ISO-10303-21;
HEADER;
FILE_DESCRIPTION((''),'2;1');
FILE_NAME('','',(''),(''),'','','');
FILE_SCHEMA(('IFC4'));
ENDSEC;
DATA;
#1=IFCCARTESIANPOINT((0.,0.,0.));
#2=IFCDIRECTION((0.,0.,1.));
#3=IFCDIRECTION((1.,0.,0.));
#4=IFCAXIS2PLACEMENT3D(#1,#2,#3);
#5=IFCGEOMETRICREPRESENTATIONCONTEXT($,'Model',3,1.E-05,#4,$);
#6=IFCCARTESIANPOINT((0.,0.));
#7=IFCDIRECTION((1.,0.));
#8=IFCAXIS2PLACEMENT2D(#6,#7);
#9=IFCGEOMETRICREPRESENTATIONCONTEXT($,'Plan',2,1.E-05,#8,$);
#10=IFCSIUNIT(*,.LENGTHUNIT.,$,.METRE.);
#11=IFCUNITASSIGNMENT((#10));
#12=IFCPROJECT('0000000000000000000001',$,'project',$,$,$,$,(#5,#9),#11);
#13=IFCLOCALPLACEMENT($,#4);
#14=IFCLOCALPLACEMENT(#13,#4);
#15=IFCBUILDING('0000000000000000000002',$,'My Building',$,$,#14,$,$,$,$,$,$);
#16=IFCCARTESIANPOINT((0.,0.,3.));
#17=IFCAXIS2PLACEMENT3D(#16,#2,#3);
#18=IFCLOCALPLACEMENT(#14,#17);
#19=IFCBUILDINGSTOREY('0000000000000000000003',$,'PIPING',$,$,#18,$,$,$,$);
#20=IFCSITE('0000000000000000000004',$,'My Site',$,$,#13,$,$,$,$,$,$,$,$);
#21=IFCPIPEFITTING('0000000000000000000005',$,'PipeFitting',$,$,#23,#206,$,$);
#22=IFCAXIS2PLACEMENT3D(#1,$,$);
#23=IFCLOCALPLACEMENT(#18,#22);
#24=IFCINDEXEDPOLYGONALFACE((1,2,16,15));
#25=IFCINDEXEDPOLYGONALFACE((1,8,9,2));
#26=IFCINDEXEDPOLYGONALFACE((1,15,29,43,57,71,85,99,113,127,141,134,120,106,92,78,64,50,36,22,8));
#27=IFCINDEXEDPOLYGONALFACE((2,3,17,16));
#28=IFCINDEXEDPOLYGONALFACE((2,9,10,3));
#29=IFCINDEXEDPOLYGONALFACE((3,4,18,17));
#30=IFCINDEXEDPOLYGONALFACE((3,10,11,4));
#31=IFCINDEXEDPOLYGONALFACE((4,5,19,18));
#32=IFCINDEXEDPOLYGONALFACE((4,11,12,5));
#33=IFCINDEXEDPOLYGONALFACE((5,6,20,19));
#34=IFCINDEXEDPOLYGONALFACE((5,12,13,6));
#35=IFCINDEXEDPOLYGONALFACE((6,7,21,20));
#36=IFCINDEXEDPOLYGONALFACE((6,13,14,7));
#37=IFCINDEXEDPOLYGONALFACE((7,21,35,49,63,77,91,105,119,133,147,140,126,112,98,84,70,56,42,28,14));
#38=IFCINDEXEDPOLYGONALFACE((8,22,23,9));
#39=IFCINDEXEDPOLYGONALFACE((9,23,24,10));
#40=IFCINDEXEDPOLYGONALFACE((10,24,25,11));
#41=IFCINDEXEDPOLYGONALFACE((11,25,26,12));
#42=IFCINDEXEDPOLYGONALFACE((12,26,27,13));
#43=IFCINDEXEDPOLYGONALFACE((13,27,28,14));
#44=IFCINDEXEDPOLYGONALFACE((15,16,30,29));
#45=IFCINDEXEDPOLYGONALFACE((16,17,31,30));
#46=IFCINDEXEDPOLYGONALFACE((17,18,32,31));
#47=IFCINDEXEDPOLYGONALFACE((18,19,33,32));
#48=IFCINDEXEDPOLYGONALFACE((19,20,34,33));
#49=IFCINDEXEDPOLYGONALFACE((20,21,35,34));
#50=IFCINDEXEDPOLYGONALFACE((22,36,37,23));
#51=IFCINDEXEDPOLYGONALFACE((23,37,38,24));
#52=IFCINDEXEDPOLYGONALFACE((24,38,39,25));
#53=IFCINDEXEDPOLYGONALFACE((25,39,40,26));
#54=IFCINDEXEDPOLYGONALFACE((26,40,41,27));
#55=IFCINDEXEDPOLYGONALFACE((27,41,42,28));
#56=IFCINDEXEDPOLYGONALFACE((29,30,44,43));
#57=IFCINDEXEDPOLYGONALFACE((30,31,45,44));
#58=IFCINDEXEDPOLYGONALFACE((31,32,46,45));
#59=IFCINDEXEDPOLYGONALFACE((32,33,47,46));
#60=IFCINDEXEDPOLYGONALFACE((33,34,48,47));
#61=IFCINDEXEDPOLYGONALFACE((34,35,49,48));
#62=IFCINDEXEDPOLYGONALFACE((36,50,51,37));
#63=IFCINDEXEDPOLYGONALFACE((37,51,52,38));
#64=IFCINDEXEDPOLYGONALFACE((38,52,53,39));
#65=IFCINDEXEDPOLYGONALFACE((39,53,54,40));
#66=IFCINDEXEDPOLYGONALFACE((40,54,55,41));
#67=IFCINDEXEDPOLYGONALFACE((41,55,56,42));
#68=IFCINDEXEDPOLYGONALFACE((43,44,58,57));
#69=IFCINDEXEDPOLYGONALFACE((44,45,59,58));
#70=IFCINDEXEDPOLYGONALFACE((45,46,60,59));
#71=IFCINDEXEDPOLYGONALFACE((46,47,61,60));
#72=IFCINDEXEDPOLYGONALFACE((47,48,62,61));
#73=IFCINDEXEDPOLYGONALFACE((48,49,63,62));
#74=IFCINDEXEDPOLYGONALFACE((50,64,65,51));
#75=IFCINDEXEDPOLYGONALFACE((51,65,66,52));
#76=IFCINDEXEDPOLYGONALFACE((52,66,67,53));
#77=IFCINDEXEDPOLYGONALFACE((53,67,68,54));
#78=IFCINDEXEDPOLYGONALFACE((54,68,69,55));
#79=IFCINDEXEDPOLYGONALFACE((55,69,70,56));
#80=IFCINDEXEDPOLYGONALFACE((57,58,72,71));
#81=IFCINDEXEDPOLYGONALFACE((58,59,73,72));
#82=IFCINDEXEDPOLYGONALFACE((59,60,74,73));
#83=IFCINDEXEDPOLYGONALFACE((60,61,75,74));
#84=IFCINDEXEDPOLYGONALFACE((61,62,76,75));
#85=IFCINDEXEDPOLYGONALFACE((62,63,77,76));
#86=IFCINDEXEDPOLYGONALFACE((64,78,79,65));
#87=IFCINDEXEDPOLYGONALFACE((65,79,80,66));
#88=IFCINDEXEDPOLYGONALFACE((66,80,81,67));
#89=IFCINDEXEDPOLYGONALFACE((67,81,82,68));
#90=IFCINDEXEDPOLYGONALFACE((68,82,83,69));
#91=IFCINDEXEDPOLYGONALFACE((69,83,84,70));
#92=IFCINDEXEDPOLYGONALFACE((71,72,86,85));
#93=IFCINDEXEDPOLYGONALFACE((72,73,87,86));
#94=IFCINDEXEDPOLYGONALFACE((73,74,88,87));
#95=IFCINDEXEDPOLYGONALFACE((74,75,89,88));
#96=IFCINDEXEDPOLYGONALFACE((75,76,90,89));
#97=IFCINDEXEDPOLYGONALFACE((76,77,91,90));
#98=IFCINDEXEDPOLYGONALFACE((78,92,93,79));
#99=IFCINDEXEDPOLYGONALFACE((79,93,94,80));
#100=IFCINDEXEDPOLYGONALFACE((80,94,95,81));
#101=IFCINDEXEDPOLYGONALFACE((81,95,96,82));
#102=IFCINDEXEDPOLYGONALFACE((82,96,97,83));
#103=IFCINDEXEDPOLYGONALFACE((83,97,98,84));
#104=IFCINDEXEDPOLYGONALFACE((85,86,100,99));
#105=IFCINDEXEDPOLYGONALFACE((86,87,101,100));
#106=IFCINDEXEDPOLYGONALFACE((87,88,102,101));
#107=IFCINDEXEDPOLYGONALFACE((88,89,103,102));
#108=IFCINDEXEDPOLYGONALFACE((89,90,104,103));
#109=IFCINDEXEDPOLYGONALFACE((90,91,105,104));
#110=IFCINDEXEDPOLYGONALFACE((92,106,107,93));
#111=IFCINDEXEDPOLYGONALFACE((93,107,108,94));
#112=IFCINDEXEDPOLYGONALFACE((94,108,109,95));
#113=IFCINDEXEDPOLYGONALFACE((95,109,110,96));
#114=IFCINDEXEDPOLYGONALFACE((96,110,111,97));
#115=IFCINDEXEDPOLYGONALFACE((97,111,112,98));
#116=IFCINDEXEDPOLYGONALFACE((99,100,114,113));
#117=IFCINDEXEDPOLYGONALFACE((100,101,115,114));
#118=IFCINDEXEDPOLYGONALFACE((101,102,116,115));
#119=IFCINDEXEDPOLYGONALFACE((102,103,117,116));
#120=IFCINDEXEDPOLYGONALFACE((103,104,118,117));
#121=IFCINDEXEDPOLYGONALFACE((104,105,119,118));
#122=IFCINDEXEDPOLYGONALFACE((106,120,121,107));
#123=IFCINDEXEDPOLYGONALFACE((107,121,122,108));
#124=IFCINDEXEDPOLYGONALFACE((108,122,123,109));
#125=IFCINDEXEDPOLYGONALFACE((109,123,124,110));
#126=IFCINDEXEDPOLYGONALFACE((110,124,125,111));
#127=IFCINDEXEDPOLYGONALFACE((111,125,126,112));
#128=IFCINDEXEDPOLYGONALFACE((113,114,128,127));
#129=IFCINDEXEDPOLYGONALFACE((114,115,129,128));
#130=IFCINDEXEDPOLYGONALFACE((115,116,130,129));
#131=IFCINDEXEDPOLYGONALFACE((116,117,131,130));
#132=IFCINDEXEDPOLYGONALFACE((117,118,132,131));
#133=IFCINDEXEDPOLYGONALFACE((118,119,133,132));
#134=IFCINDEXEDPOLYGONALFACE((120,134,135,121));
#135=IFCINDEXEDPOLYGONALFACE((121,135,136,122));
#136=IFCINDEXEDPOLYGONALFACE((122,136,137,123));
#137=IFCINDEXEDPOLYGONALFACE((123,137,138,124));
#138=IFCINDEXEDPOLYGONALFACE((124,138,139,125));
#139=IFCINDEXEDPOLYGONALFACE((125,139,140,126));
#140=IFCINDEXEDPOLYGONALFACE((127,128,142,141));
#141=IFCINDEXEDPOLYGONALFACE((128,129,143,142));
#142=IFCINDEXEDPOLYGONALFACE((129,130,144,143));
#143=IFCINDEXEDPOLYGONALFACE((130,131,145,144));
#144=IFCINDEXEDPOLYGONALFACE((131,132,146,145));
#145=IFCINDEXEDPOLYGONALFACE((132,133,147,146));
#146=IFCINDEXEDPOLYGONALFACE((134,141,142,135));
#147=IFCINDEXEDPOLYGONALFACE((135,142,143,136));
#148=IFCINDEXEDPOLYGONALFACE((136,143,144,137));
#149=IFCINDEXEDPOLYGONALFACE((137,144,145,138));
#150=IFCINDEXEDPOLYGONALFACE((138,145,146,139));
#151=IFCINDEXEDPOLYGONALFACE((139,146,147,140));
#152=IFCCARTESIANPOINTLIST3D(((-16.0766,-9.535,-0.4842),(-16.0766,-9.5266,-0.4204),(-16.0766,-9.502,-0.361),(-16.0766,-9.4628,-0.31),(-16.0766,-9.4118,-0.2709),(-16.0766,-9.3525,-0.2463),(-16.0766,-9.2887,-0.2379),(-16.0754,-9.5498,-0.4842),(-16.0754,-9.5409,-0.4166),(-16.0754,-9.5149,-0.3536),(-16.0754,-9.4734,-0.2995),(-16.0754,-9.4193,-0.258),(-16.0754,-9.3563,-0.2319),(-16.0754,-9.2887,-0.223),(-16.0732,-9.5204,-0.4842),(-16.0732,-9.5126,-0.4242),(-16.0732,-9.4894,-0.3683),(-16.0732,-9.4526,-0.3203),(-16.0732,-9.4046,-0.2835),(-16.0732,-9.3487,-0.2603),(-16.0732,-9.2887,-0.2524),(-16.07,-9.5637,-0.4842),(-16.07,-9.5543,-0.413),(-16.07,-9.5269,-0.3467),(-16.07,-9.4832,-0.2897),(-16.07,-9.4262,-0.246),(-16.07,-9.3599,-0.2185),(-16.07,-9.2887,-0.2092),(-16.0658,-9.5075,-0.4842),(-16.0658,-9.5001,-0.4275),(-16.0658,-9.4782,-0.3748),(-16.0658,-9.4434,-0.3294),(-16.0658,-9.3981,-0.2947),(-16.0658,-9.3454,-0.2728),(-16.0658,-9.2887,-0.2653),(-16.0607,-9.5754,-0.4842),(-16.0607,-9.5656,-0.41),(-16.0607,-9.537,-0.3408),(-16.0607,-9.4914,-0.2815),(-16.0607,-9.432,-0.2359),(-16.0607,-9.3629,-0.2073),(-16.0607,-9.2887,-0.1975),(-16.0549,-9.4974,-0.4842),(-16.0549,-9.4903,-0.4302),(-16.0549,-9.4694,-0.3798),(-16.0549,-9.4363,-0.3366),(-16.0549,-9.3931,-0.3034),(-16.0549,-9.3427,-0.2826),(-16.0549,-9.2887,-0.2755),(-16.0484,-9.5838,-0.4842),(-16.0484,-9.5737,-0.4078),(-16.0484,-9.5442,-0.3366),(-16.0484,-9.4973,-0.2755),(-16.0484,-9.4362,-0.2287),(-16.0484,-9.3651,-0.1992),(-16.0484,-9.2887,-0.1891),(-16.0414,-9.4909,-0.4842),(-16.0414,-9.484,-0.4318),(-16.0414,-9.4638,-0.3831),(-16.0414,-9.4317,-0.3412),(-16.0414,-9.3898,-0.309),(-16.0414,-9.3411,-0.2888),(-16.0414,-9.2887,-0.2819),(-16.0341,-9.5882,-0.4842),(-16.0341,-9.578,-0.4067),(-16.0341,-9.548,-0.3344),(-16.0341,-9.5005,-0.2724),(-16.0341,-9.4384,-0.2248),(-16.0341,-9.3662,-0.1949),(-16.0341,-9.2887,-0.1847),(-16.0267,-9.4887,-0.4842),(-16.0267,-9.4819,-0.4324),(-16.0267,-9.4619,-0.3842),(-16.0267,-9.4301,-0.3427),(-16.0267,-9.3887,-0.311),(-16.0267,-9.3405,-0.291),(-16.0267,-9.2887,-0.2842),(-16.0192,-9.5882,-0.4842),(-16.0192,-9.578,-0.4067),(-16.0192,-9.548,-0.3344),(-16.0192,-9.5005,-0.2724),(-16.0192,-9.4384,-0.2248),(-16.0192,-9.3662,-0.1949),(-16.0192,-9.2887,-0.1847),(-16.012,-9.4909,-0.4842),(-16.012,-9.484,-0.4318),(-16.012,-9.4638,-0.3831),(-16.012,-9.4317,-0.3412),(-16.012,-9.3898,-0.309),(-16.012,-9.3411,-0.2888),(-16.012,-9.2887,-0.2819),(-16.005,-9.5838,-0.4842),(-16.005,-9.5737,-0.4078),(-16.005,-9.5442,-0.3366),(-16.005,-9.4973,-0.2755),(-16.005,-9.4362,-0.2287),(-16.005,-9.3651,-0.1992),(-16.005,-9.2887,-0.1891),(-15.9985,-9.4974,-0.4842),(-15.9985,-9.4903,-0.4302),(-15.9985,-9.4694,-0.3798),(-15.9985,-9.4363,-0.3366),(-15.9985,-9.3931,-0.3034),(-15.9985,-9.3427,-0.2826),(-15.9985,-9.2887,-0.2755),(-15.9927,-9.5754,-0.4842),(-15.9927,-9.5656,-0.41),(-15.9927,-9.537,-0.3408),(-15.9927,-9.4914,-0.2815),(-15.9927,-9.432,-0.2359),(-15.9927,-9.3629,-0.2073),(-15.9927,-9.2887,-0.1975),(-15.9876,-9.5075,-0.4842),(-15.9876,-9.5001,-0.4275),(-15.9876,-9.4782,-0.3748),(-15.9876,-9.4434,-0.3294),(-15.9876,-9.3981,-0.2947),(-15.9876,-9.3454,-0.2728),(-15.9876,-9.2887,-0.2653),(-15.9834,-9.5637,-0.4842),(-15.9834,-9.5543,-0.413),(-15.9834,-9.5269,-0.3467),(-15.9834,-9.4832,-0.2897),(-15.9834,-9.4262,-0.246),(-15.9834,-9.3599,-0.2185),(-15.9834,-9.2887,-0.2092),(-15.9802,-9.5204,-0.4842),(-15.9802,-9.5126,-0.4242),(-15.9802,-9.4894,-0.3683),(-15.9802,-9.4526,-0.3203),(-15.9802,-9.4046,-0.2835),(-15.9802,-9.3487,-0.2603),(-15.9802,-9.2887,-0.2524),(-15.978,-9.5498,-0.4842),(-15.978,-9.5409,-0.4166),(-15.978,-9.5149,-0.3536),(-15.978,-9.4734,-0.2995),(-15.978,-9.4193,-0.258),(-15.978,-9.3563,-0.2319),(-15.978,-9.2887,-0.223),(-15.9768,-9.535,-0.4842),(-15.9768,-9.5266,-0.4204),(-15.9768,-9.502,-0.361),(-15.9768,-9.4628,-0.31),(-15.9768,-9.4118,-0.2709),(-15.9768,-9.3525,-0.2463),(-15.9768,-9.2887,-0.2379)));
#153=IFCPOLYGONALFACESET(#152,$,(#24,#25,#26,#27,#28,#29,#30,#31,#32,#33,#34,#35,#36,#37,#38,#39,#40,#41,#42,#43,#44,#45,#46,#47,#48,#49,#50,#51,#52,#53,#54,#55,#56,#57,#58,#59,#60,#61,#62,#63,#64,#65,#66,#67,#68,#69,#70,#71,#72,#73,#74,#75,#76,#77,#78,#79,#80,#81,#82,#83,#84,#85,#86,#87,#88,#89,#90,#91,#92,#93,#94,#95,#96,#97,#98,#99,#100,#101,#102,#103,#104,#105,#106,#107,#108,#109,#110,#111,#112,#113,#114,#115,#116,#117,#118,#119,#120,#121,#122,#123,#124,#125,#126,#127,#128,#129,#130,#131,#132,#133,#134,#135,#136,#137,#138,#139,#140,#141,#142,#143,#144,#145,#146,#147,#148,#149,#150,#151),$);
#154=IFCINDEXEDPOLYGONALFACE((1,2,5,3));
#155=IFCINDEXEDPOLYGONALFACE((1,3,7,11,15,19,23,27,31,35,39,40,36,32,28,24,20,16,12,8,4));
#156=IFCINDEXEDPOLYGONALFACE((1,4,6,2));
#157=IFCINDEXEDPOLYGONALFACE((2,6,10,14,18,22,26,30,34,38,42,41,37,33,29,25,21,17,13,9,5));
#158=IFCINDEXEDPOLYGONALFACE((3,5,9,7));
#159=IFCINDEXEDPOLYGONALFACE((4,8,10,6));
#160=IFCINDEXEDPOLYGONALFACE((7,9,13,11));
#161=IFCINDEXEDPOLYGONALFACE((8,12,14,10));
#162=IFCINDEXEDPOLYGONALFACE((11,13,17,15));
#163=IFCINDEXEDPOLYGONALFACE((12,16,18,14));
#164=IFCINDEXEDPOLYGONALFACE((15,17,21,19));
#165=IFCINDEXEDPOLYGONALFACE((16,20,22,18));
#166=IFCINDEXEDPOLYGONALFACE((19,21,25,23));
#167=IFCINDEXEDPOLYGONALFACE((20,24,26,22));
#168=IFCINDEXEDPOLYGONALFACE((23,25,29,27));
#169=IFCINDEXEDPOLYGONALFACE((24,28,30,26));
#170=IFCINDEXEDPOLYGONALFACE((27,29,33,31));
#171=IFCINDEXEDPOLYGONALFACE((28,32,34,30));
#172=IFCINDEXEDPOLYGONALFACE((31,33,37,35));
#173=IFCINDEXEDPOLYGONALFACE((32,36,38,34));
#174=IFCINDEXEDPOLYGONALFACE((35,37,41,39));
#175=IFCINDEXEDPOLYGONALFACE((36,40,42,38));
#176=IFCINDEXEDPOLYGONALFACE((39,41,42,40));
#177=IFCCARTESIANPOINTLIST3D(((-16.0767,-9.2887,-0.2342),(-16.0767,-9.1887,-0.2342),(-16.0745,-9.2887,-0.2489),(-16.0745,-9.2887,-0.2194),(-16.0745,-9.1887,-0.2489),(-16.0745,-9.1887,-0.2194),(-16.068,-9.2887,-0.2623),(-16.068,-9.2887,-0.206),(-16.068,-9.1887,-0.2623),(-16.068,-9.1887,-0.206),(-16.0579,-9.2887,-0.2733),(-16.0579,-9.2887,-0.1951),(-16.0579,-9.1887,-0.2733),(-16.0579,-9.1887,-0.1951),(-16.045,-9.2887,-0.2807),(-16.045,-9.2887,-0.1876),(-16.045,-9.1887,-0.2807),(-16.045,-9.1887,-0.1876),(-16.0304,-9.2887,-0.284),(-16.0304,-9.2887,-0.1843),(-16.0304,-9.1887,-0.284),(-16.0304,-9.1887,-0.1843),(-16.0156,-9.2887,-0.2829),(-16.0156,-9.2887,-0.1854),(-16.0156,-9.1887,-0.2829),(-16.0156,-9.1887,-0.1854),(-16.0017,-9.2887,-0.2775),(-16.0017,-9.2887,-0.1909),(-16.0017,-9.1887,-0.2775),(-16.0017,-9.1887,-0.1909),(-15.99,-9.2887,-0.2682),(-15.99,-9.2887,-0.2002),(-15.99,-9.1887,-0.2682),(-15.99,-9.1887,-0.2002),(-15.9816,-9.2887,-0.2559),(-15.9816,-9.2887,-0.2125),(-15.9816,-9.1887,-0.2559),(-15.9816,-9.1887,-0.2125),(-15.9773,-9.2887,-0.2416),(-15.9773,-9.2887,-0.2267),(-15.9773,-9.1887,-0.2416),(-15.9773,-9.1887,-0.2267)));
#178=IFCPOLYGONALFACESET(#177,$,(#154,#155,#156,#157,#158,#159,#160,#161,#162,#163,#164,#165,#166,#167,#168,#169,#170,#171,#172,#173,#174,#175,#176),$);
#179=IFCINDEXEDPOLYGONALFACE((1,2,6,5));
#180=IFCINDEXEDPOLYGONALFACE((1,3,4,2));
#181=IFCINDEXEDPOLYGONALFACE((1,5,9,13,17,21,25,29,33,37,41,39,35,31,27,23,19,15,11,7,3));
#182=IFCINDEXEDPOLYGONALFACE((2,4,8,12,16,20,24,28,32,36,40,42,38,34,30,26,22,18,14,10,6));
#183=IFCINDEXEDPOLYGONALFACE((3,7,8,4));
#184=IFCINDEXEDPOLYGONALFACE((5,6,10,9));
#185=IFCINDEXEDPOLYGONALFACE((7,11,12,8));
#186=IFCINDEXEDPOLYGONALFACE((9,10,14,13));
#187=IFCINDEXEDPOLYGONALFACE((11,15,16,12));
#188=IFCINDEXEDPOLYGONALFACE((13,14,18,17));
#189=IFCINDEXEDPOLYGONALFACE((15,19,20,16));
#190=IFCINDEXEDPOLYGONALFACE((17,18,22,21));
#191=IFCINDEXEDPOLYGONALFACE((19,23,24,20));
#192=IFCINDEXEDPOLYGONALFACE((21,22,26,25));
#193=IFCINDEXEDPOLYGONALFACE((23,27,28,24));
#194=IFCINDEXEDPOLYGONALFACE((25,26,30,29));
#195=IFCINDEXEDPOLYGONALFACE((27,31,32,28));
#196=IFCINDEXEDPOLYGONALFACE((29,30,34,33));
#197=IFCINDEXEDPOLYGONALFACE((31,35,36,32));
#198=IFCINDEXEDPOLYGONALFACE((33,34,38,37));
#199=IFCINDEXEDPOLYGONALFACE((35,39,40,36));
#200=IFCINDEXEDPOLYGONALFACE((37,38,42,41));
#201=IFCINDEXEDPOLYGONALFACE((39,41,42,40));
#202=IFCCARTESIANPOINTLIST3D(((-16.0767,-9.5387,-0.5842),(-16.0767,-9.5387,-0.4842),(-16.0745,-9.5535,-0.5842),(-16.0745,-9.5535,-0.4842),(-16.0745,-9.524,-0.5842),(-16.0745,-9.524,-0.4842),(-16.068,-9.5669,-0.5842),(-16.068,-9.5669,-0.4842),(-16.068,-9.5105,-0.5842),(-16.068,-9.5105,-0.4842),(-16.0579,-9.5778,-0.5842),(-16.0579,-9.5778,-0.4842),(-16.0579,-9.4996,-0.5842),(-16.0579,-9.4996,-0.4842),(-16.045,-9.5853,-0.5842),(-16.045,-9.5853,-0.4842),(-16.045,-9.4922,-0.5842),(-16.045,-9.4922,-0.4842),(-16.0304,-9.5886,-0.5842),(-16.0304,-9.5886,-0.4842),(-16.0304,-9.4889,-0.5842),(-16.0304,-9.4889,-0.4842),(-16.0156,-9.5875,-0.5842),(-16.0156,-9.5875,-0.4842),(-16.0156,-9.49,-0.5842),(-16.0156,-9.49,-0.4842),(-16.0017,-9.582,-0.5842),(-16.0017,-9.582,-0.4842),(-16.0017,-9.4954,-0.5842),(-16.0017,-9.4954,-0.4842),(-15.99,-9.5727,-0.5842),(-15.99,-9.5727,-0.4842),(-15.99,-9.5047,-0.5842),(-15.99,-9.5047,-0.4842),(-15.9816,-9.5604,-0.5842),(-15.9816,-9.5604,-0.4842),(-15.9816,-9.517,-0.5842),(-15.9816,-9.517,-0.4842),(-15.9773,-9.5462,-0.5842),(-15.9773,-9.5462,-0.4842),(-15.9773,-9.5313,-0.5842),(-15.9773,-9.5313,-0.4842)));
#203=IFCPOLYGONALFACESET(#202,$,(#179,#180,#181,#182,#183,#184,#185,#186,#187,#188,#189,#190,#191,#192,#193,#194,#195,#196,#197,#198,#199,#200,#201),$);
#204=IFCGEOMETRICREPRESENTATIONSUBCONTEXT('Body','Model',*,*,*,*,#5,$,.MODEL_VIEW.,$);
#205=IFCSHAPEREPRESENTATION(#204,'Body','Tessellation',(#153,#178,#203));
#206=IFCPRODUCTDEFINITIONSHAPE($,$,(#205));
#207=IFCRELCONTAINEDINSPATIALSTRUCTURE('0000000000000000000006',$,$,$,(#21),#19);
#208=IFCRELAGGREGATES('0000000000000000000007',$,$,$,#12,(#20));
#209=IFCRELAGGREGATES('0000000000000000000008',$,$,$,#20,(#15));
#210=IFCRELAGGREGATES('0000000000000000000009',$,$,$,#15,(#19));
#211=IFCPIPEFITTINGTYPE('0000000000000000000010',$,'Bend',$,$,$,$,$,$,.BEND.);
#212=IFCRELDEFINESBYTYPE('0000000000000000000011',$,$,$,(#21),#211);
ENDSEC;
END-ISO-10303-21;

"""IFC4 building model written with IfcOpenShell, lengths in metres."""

from ifc_helpers import new_model, entity, si_unit, frame, origin_with_axes, origin_2d_with_axis, place, context, subcontext, project, spatial, circle, extrude, source, transform, mapped, type_object, type_shapes, element, save


model = new_model("IFC4")

# Units and contexts
model_context = context("Model", 3, precision=1e-05, world=origin_with_axes())
plan_context = context("Plan", 2, precision=1e-05, world=origin_2d_with_axis())
body_context = subcontext(model_context, "Body", "Model", "MODEL_VIEW")
ifc_project = project(units=[si_unit("LENGTHUNIT", "METRE")], contexts=[model_context, plan_context])

# Site, building, storey
site_placement = place(None, origin_with_axes())
site = spatial("IfcSite", under=ifc_project, at=site_placement, Name="My Site")
building_placement = place(site_placement, origin_with_axes())
building = spatial("IfcBuilding", under=site, at=building_placement, Name="My Building")
storey_placement = place(building_placement, frame((0.0, 0.0, 3.0), z_axis=(0.0, 0.0, 1.0), x_axis=(1.0, 0.0, 0.0)))
storey = spatial("IfcBuildingStorey", under=building, at=storey_placement, Name="PIPING")

# Pipe fitting
pipe_fitting_type = type_object("IfcPipeFittingType", Name="Bend", PredefinedType="BEND")
shared_shape = source(origin_with_axes(), body_context, "Body", "SolidModel", [
    entity("IfcSweptDiskSolid", entity("IfcIndexedPolyCurve", entity("IfcCartesianPointList3D", [[0.0, 0.0, -0.1], [0.0, -0.0732, -0.2768], [0.0, -0.25, -0.35]]), [entity("IfcArcIndex", [1, 2, 3])]), 0.05),
    extrude(circle(Radius=0.05), origin_with_axes(), (0.0, 0.0, -1.0), 0.1),
    extrude(circle(Radius=0.05), frame((0.0, -0.25, -0.35), z_axis=(0.0, -1.0, 0.0), x_axis=(1.0, 0.0, 0.0)), (0.0, 0.0, 1.0), 0.1),
])
type_shapes(pipe_fitting_type, [shared_shape])
for number, where, z_axis, x_axis, name in (
    (1, (-16.0267, -9.1887, -0.2342), (0.0, 1.0, 0.0), (-1.0, 0.0, 0.0), "PipeFitting"),
):
    element("IfcPipeFitting", number, at=place(storey_placement, frame(where, z_axis=z_axis, x_axis=x_axis)), inside=storey, type_object=pipe_fitting_type, Name=name, context=body_context, shape_type="MappedRepresentation", body=[
        mapped(shared_shape, transform((0.0, 0.0, 0.0), x_axis=(1.0, 0.0, 0.0), y_axis=(0.0, 1.0, 0.0), z_axis=(0.0, 0.0, 1.0), scale=1.0)),
    ])

save(model, "model.ifc")
